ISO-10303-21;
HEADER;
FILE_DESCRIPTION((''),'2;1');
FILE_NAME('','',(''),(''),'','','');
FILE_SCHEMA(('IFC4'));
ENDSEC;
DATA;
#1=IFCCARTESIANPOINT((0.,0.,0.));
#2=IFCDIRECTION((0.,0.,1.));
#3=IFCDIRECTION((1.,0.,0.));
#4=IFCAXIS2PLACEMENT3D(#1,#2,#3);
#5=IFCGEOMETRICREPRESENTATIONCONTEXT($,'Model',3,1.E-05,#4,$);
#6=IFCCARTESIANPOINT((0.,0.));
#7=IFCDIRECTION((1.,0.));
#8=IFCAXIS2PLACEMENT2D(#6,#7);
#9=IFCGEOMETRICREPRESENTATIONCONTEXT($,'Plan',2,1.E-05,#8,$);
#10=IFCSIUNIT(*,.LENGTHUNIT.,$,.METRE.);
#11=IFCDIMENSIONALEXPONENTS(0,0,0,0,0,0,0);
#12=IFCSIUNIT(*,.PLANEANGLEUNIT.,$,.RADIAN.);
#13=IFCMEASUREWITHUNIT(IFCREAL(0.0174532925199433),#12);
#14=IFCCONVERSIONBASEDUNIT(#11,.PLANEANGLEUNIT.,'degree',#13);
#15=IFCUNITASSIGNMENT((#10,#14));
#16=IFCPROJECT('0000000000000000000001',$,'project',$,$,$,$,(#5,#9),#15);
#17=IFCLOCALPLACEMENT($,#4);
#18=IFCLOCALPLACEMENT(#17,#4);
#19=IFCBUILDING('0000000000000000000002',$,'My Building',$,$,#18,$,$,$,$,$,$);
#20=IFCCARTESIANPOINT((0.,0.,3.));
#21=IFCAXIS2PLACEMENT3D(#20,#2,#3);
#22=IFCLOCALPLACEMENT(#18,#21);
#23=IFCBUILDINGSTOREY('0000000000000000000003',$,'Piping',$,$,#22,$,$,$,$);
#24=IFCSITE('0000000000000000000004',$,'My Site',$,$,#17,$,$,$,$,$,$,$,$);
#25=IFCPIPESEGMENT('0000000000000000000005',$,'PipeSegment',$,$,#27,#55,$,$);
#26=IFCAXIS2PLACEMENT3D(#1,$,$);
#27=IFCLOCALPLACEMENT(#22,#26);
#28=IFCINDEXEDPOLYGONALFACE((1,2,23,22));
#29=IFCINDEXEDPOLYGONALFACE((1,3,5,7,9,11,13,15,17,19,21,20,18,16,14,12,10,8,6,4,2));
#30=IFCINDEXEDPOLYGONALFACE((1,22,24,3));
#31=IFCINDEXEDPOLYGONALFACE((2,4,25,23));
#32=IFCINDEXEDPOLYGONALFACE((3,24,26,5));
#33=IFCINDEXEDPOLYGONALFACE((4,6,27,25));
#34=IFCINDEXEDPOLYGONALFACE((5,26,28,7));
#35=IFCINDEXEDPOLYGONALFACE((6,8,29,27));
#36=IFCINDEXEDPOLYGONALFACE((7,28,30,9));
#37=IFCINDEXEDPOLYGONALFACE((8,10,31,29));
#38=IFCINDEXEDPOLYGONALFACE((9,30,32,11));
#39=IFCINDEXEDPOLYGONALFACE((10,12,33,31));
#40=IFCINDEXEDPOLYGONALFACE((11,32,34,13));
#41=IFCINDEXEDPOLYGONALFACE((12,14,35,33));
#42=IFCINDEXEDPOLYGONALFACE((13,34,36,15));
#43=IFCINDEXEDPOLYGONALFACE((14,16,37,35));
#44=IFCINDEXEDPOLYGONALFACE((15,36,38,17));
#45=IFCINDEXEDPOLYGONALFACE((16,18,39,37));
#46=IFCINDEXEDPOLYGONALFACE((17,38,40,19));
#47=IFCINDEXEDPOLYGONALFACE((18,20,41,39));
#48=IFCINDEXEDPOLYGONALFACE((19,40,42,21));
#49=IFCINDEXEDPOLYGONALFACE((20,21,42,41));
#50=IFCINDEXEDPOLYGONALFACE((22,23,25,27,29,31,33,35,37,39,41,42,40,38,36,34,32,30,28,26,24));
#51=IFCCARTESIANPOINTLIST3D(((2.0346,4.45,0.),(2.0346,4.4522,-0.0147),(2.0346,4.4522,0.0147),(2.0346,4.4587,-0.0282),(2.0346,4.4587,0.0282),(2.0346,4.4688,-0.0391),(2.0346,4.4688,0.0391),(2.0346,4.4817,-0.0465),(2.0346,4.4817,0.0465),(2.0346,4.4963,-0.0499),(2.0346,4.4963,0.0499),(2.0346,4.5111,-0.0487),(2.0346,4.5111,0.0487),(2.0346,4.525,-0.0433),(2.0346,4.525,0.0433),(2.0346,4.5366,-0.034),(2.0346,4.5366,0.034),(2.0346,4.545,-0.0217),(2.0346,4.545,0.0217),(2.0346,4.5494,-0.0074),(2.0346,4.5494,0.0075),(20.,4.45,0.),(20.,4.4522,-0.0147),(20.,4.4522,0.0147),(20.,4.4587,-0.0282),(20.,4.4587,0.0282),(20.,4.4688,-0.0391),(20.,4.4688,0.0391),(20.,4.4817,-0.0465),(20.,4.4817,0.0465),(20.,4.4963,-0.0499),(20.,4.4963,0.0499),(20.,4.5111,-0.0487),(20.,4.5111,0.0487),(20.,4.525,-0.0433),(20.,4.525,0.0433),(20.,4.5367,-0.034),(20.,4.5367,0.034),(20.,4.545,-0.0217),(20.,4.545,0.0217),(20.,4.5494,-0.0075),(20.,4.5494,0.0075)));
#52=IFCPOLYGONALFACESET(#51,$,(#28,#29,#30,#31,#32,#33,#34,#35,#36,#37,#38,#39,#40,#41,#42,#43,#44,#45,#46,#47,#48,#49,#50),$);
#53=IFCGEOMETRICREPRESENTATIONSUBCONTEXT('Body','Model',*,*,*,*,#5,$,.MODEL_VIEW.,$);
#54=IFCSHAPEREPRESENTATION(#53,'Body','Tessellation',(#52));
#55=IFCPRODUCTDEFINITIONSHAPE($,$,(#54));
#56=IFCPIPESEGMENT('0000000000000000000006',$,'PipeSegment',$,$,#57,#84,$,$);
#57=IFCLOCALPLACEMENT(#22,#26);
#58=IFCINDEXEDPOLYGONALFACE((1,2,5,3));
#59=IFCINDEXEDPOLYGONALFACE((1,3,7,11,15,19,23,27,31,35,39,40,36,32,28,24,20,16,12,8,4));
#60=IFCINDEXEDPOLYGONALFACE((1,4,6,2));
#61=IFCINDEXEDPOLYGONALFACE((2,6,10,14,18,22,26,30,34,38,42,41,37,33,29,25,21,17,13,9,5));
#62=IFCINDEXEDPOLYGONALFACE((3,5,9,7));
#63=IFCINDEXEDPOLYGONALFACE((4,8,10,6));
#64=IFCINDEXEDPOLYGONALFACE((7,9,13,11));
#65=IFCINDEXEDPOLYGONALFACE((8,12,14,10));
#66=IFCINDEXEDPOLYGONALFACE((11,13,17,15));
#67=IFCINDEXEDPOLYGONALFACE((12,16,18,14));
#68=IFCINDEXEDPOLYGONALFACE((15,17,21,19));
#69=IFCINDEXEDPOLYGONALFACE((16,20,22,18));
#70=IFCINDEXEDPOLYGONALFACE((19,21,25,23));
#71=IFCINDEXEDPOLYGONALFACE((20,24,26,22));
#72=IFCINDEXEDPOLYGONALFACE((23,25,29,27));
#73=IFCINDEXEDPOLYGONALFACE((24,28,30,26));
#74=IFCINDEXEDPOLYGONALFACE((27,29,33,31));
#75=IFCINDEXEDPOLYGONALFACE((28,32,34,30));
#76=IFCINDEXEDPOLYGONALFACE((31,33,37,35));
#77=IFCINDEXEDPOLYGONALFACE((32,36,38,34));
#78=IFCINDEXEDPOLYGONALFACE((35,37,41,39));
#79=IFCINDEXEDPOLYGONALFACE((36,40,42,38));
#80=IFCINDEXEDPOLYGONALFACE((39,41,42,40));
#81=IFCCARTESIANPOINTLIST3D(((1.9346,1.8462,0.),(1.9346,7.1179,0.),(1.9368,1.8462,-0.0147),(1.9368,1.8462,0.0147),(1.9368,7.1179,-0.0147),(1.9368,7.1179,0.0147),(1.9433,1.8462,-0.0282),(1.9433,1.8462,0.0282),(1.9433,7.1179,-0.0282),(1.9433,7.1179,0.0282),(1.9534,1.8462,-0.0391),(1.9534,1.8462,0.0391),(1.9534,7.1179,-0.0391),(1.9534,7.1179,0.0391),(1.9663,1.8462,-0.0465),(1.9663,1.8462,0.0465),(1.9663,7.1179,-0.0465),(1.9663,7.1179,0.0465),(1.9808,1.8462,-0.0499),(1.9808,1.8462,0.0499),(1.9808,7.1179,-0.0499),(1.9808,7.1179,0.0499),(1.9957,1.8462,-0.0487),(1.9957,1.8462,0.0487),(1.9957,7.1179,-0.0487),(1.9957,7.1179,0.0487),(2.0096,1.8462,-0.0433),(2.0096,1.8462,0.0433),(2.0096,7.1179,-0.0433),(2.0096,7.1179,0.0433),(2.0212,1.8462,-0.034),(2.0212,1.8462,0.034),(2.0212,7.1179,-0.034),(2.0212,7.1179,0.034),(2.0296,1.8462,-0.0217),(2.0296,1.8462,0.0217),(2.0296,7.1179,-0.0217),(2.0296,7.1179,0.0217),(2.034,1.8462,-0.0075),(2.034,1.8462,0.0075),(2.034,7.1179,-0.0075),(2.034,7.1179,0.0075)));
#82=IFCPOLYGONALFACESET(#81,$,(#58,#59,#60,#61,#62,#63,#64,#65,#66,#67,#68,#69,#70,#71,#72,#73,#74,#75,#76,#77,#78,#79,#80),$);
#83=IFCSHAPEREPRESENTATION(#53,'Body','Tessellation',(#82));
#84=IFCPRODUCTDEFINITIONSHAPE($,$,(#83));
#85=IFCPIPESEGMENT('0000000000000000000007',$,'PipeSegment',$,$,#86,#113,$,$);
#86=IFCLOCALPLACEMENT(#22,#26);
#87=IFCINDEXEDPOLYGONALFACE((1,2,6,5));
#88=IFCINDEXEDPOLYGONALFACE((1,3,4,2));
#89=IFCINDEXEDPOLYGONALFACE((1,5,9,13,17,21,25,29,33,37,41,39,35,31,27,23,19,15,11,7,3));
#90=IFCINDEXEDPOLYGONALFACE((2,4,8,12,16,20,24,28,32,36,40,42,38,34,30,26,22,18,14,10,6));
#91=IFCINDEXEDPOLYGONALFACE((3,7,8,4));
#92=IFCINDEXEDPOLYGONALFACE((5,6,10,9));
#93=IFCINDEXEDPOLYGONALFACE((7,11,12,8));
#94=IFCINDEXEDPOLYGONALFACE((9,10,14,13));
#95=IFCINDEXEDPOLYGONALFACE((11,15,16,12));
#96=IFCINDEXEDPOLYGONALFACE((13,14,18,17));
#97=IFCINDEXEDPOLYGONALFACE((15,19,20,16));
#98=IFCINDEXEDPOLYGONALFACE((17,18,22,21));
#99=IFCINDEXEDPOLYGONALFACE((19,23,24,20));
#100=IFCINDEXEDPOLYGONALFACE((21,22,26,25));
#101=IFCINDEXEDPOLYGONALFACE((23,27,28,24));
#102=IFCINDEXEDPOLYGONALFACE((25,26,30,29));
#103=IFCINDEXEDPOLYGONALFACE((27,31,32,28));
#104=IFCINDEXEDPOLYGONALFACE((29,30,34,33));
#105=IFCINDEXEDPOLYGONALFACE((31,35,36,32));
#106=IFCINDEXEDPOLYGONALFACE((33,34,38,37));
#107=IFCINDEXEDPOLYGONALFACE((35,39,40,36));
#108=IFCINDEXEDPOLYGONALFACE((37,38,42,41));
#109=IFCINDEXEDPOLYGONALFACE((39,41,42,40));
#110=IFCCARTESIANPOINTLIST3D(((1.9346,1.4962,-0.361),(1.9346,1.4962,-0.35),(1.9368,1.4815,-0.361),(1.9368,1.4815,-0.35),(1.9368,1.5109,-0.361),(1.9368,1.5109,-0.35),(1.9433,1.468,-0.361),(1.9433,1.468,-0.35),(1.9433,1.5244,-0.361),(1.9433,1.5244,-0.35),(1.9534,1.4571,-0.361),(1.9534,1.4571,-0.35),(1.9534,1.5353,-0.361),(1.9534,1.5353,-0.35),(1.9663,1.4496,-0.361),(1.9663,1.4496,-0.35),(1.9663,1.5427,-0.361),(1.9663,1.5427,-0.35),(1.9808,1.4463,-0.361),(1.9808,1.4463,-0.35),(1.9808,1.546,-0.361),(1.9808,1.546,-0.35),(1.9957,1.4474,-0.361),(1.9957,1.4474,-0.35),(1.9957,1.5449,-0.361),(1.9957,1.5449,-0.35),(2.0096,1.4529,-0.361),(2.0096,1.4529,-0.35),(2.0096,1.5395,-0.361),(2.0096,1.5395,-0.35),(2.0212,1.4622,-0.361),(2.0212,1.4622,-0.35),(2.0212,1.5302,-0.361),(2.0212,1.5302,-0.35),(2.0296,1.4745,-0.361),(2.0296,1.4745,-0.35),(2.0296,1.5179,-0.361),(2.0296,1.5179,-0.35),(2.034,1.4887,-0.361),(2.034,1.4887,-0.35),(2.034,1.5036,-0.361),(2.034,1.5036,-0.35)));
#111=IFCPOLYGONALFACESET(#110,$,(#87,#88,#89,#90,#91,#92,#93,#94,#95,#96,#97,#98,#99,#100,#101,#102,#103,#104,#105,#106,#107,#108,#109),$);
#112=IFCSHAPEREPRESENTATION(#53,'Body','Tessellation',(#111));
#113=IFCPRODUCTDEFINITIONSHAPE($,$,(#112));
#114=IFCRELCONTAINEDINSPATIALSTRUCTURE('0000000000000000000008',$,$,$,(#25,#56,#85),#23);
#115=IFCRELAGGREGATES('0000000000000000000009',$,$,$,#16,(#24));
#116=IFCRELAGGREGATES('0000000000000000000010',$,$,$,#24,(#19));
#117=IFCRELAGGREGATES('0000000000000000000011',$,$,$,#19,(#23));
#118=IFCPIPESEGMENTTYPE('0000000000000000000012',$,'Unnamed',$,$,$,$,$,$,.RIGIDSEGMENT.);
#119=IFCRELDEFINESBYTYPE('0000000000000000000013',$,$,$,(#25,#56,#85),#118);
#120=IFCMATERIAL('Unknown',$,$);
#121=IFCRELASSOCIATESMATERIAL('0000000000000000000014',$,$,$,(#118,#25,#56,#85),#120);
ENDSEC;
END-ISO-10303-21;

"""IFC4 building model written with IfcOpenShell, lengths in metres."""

from ifc_helpers import new_model, entity, si_unit, converted_unit, frame, origin_with_axes, origin_2d_with_axis, place, context, subcontext, project, spatial, circle, extrude, material, material_profile, profile_set, profile_usage, type_object, element, save


model = new_model("IFC4")

# Units and contexts
model_context = context("Model", 3, precision=1e-05, world=origin_with_axes())
plan_context = context("Plan", 2, precision=1e-05, world=origin_2d_with_axis())
body_context = subcontext(model_context, "Body", "Model", "MODEL_VIEW")
ifc_project = project(units=[si_unit("LENGTHUNIT", "METRE"), converted_unit("PLANEANGLEUNIT", "degree", entity("IfcReal", 0.0174532925199433), si_unit("PLANEANGLEUNIT", "RADIAN"), dimensions=[0, 0, 0, 0, 0, 0, 0])], contexts=[model_context, plan_context])

# Site, building, storey
site_placement = place(None, origin_with_axes())
site = spatial("IfcSite", under=ifc_project, at=site_placement, Name="My Site")
building_placement = place(site_placement, origin_with_axes())
building = spatial("IfcBuilding", under=site, at=building_placement, Name="My Building")
storey_placement = place(building_placement, frame((0.0, 0.0, 3.0), z_axis=(0.0, 0.0, 1.0), x_axis=(1.0, 0.0, 0.0)))
storey = spatial("IfcBuildingStorey", under=building, at=storey_placement, Name="Piping")

# Pipe segments
ifc_material = material(Name="Unknown")
ifc_material_profile = material_profile(ifc_material, circle(Radius=0.05))
ifc_profile_set = profile_set([ifc_material_profile])
ifc_profile_usage_1 = profile_usage(ifc_profile_set, cardinal=5)
pipe_segment_type = type_object("IfcPipeSegmentType", Name="Unnamed", PredefinedType="RIGIDSEGMENT", material=ifc_profile_set)
pipe_segment_1_placement = place(storey_placement, frame((20.0, 4.5, 0.0), z_axis=(-1.0, 0.0, 0.0), x_axis=(0.0, -1.0, 0.0)))
element("IfcPipeSegment", 1, at=pipe_segment_1_placement, inside=storey, type_object=pipe_segment_type, material=ifc_profile_usage_1, Name="PipeSegment", context=body_context, shape_type="SweptSolid", body=[
    extrude(circle(Radius=0.05), origin_with_axes(), (0.0, 0.0, 1.0), 17.9654),
])
ifc_profile_usage_2 = profile_usage(ifc_profile_set, cardinal=5)
pipe_segment_2_placement = place(storey_placement, frame((1.9846, 1.8462, 0.0), z_axis=(0.0, 1.0, 0.0), x_axis=(-1.0, 0.0, 0.0)))
element("IfcPipeSegment", 2, at=pipe_segment_2_placement, inside=storey, type_object=pipe_segment_type, material=ifc_profile_usage_2, Name="PipeSegment", context=body_context, shape_type="SweptSolid", body=[
    extrude(circle(Radius=0.05), origin_with_axes(), (0.0, 0.0, 1.0), 5.2718),
])
ifc_profile_usage_3 = profile_usage(ifc_profile_set, cardinal=5)
pipe_segment_3_placement = place(storey_placement, frame((1.9846, 1.4962, -0.35), z_axis=(0.0, 0.0, -1.0), x_axis=(-1.0, 0.0, 0.0)))
element("IfcPipeSegment", 3, at=pipe_segment_3_placement, inside=storey, type_object=pipe_segment_type, material=ifc_profile_usage_3, Name="PipeSegment", context=body_context, shape_type="SweptSolid", body=[
    extrude(circle(Radius=0.05), origin_with_axes(), (0.0, 0.0, 1.0), 0.011),
])

save(model, "model.ifc")
